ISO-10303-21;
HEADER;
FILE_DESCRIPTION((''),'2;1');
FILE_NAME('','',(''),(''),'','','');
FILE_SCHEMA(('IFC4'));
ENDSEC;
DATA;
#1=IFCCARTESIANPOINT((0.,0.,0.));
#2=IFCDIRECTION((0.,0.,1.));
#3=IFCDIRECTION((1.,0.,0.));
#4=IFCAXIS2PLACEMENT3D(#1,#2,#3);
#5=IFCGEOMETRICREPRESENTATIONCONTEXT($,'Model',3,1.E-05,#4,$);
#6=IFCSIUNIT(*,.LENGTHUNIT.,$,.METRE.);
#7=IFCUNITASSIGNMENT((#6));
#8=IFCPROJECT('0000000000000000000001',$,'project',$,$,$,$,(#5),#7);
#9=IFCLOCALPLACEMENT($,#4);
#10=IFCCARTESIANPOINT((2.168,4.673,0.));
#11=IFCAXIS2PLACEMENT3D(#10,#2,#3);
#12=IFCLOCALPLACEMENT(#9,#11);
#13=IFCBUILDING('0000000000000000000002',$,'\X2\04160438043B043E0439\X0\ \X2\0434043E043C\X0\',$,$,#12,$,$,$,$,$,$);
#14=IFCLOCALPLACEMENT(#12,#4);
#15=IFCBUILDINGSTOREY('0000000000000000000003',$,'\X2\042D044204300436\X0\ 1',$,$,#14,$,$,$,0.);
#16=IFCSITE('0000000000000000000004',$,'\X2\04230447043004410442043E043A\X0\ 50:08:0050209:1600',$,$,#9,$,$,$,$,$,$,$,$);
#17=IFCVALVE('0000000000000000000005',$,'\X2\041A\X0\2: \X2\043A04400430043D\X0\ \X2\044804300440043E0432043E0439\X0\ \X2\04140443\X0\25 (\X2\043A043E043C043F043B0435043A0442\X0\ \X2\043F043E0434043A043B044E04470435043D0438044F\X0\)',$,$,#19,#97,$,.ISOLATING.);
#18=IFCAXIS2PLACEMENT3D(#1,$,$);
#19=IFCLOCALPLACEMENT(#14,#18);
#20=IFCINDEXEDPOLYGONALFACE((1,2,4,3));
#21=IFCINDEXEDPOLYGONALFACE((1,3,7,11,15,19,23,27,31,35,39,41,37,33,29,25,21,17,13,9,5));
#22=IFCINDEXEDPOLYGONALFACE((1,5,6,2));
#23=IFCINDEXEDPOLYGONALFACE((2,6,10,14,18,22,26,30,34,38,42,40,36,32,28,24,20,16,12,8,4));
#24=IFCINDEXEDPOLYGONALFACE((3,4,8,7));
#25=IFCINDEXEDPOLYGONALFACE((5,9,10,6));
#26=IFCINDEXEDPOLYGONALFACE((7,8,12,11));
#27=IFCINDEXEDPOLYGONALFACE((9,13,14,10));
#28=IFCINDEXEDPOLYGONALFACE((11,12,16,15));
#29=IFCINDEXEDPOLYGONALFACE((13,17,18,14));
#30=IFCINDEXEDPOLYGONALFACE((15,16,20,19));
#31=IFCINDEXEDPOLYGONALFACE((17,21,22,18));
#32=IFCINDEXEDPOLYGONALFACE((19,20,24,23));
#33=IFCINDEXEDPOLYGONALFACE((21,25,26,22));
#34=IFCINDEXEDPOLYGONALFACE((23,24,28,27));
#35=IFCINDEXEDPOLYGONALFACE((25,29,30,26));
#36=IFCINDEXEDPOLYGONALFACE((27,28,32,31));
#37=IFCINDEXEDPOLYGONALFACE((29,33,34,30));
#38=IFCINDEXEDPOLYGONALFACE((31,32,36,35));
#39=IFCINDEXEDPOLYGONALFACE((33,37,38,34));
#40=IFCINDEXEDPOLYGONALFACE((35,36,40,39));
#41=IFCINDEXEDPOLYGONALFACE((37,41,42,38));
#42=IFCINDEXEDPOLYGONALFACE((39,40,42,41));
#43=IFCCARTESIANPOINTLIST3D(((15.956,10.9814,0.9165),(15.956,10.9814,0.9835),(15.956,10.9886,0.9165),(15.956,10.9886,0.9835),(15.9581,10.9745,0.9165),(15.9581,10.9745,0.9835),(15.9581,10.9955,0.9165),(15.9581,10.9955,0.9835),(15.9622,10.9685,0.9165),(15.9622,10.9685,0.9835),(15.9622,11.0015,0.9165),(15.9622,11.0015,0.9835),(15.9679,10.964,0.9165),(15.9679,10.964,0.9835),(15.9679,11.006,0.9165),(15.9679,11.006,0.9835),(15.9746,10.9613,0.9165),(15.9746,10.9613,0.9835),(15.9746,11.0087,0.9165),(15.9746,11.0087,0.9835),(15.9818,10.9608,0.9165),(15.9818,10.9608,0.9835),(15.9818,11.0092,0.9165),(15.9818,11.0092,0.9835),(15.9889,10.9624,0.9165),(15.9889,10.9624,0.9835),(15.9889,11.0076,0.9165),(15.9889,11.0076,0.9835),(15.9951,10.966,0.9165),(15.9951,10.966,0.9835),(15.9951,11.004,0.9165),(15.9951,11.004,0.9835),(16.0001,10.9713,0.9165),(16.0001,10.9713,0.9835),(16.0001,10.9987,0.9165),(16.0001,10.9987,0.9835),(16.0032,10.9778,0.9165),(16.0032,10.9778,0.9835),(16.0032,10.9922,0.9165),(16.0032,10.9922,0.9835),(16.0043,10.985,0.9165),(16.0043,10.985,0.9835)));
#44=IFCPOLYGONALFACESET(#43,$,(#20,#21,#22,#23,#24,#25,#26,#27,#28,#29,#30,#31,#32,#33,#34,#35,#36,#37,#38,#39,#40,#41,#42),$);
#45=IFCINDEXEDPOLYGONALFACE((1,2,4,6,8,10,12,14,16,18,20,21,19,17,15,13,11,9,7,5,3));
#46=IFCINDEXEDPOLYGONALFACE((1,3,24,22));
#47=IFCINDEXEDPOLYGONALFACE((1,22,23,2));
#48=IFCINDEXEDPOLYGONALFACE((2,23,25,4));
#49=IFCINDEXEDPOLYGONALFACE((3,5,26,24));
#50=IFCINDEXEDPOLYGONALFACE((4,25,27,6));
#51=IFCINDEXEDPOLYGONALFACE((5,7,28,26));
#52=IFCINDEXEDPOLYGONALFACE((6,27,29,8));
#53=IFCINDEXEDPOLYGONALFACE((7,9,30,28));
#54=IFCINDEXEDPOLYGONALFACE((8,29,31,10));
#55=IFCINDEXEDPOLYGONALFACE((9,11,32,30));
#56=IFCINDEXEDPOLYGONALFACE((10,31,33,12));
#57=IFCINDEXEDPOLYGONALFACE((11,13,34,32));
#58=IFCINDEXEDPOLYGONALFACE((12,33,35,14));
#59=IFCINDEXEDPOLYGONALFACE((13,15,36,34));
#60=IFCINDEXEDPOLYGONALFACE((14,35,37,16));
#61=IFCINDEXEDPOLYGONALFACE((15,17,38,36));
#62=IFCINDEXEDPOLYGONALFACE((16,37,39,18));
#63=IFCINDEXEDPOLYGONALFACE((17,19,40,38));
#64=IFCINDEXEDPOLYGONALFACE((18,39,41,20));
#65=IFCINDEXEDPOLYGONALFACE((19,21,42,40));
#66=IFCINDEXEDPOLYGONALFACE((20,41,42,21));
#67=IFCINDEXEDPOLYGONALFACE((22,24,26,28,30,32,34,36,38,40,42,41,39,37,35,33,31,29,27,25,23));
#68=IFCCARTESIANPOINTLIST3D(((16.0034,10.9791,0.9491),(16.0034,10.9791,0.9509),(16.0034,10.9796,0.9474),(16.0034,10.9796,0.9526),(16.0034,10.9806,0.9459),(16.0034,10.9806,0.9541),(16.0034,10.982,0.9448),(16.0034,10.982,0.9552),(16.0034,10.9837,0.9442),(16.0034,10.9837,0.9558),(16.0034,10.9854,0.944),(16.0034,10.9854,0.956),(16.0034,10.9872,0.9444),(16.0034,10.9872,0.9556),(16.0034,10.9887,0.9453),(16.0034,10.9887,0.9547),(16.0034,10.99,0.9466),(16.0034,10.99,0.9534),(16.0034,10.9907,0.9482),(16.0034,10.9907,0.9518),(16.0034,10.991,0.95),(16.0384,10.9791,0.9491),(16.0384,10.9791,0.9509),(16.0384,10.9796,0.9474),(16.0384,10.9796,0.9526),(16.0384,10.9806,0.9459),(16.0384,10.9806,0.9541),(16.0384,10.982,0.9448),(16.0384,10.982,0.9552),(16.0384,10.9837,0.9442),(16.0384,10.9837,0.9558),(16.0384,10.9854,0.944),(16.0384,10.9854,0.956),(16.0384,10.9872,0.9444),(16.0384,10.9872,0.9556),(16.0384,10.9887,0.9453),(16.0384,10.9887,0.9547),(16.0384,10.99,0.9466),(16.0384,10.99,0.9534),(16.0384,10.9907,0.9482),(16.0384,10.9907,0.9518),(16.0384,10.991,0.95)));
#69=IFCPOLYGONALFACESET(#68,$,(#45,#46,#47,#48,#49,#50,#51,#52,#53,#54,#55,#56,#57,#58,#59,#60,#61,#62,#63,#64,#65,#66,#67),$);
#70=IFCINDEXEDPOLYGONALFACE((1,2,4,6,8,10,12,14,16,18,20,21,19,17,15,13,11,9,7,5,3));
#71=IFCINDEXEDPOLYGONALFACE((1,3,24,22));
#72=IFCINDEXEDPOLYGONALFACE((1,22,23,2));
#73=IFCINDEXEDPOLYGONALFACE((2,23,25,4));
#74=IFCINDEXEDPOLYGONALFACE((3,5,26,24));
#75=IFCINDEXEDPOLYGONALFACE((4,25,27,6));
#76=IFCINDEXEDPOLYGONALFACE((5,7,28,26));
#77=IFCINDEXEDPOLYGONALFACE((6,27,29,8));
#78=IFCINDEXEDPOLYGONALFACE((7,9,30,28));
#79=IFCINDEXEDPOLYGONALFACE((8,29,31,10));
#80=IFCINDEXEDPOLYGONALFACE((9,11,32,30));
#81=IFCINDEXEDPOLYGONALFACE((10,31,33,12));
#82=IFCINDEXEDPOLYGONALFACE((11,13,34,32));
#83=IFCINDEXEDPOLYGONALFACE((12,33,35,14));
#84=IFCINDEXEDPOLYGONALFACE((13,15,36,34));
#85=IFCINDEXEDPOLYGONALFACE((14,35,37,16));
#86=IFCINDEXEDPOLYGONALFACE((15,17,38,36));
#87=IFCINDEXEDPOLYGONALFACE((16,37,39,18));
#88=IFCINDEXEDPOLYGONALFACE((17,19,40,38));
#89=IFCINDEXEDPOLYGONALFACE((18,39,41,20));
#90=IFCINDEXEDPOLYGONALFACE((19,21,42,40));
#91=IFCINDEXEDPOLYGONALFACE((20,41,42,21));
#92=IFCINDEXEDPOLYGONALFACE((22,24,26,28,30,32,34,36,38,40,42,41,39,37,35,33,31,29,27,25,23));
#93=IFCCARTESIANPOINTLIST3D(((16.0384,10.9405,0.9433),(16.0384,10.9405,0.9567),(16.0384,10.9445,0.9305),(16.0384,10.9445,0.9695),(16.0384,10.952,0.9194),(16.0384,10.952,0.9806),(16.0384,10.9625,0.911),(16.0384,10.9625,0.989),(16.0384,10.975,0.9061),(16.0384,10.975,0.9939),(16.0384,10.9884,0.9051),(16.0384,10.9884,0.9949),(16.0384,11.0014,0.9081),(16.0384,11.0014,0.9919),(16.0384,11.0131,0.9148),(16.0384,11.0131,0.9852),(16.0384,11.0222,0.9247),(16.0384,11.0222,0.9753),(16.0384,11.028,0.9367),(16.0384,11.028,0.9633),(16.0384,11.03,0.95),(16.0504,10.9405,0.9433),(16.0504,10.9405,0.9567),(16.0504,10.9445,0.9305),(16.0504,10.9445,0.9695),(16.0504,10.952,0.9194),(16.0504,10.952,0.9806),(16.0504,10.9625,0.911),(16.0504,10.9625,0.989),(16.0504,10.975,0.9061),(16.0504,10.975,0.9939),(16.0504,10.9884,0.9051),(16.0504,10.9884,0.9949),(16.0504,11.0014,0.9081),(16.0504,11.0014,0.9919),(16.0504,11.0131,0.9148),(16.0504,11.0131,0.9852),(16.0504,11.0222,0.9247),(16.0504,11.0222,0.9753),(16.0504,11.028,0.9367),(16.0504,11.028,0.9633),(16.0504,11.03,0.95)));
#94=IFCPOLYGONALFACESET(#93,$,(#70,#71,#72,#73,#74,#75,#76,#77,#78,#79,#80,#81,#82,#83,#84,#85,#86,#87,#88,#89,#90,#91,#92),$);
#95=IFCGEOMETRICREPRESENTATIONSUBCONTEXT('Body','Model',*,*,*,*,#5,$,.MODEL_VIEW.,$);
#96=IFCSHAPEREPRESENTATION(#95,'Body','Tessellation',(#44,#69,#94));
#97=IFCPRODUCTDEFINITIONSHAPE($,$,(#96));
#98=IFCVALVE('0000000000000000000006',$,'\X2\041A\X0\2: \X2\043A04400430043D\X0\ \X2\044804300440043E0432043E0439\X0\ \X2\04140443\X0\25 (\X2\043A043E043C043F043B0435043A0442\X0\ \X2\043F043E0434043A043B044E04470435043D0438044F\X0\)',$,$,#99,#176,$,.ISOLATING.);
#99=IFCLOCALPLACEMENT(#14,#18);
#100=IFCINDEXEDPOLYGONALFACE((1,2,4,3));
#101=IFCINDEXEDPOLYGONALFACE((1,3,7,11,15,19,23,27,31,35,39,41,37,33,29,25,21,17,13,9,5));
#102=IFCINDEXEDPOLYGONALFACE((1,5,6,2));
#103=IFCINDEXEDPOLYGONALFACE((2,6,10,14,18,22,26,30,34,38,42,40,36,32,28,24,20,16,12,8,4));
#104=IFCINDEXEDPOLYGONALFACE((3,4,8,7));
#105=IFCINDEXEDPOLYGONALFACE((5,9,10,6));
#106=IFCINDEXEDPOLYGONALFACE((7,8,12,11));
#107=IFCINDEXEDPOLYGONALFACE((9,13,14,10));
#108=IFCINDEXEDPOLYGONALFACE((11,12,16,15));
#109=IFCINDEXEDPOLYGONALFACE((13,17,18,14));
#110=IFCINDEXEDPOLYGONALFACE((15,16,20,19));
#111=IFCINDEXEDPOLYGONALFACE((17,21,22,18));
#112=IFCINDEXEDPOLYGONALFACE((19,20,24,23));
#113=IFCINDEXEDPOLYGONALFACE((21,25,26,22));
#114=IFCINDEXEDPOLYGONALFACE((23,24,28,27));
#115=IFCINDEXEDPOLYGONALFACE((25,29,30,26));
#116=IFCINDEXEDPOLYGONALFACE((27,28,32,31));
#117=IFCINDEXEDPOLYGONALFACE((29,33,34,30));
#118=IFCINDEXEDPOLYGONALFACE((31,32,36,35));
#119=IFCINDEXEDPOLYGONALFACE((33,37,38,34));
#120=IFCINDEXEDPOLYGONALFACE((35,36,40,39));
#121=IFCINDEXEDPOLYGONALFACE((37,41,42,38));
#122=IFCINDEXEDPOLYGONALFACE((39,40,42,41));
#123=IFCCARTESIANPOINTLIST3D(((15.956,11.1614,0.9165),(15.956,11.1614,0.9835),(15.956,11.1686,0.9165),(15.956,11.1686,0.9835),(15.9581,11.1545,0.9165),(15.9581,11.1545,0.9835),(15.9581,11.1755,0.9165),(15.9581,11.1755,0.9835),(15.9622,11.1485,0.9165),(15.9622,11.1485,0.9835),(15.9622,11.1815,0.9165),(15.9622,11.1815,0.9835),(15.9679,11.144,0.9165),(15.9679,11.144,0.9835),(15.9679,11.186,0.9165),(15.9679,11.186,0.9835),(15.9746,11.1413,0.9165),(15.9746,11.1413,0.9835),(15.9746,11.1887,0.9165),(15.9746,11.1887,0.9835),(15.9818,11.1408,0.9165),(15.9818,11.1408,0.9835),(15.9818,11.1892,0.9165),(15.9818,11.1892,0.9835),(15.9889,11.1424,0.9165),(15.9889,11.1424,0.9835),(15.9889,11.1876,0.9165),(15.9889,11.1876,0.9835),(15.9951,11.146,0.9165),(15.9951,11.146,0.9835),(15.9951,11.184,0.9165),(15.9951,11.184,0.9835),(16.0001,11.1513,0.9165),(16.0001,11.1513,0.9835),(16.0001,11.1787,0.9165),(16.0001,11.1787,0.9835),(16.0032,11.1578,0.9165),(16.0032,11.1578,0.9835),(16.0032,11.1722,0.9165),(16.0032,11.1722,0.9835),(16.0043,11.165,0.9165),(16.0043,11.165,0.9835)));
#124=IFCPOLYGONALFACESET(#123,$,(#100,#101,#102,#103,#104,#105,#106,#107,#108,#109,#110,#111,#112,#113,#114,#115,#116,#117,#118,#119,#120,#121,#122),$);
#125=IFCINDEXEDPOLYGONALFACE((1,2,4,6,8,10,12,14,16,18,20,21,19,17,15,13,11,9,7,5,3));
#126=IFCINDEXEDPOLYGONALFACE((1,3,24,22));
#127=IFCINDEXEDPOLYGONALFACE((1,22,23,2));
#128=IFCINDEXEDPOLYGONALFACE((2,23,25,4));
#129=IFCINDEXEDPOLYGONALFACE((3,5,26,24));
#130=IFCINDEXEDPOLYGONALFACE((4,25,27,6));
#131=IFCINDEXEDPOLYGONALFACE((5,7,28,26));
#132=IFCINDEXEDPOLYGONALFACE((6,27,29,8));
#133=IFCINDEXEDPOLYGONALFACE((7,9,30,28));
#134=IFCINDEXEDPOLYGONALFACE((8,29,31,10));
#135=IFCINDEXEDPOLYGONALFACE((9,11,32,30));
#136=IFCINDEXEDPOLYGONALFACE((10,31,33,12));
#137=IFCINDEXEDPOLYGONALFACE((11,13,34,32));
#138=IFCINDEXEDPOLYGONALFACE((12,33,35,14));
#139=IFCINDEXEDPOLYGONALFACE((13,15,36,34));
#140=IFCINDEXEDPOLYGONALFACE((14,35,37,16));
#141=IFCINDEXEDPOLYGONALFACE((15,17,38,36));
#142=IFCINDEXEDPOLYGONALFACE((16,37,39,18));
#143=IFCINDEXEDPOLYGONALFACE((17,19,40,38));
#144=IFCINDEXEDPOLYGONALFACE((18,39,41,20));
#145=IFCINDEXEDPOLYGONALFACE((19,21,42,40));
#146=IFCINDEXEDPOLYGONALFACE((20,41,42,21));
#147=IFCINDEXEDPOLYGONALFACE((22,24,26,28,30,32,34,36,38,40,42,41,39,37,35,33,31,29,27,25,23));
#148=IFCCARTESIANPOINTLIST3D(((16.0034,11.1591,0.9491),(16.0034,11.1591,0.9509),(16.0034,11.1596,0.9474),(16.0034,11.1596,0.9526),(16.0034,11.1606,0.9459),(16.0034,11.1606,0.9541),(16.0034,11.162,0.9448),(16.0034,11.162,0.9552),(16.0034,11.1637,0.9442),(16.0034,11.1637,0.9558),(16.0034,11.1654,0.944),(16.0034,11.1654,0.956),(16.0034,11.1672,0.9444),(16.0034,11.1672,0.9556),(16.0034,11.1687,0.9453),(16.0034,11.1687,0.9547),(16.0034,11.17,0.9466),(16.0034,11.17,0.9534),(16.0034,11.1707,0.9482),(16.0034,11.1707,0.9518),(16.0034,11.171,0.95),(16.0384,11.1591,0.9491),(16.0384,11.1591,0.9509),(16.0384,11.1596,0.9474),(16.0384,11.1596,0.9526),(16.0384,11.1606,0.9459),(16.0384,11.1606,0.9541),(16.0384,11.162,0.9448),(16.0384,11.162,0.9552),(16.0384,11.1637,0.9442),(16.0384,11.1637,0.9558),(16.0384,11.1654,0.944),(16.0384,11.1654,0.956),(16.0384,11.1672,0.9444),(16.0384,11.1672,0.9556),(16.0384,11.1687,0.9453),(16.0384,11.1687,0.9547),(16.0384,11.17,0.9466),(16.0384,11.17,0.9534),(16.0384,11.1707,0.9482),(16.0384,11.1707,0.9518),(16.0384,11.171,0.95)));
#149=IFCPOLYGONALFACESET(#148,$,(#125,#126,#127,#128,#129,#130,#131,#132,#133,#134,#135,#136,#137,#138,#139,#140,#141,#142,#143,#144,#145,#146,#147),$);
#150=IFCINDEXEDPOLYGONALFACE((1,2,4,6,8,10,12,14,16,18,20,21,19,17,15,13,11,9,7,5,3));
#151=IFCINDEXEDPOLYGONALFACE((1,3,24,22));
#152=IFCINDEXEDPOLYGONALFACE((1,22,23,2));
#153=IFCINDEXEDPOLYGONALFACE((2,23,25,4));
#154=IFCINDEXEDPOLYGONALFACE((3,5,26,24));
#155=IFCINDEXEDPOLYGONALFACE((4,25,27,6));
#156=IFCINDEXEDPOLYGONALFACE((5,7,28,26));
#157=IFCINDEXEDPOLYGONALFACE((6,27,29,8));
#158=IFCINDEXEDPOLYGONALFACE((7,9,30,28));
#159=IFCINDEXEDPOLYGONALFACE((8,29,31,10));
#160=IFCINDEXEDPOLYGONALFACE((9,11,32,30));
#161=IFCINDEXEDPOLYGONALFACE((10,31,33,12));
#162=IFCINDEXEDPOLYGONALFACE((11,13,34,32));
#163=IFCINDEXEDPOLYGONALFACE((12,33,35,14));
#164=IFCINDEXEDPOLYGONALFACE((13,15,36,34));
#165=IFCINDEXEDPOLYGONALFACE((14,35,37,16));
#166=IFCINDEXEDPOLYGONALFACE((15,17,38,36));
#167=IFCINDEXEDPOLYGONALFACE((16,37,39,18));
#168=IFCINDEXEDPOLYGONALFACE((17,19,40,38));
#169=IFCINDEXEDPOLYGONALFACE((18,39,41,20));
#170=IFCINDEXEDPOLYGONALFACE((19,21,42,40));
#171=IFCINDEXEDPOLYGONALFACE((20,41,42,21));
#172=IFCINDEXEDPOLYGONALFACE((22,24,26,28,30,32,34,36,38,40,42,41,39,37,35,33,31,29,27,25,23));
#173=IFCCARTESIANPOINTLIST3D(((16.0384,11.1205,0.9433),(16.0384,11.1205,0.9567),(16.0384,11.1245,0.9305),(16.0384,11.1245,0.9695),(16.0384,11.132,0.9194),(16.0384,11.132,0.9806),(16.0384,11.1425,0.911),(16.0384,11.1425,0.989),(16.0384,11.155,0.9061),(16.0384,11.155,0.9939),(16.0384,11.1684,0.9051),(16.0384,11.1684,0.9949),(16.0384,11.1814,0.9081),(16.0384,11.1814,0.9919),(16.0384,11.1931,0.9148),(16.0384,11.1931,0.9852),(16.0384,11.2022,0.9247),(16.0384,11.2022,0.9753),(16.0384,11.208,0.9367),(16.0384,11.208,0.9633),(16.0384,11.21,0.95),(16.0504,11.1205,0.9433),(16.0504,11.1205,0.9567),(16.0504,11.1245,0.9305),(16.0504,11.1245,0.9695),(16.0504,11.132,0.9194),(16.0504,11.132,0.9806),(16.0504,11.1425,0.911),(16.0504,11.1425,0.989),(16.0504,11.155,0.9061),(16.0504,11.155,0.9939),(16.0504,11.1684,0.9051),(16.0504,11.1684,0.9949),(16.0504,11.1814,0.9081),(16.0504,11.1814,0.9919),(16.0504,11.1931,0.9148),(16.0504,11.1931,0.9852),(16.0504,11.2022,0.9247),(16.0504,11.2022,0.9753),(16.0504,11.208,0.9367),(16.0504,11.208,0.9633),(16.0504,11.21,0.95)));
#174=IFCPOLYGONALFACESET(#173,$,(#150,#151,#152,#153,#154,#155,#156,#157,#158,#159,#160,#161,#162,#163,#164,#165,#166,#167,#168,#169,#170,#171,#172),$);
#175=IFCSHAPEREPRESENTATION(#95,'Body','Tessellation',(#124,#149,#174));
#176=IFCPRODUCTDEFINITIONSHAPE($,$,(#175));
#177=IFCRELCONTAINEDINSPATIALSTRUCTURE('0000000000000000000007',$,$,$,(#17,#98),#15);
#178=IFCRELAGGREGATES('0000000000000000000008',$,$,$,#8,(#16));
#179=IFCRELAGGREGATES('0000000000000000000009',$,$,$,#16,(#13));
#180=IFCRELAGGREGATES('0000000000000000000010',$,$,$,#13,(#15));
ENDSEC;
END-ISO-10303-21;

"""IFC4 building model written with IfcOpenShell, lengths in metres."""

from ifc_helpers import new_model, si_unit, frame, origin_with_axes, origin_2d, place, context, subcontext, project, spatial, circle, extrude, element, save


model = new_model("IFC4")

# Units and contexts
model_context = context("Model", 3, precision=1e-05, world=origin_with_axes())
body_context = subcontext(model_context, "Body", "Model", "MODEL_VIEW")
ifc_project = project(units=[si_unit("LENGTHUNIT", "METRE")], contexts=[model_context])

# Site, building, storey
site_placement = place(None, origin_with_axes())
site = spatial("IfcSite", under=ifc_project, at=site_placement, Name="Участок 50:08:0050209:1600")
building_placement = place(site_placement, frame((2.168, 4.673, 0.0), z_axis=(0.0, 0.0, 1.0), x_axis=(1.0, 0.0, 0.0)))
building = spatial("IfcBuilding", under=site, at=building_placement, Name="Жилой дом")
storey_placement = place(building_placement, origin_with_axes())
storey = spatial("IfcBuildingStorey", under=building, at=storey_placement, Name="Этаж 1", Elevation=0.0)

# Valves
valve_1_placement = place(storey_placement, origin_with_axes())
element("IfcValve", 1, at=valve_1_placement, inside=storey, Name="К2: кран шаровой Ду25 (комплект подключения)", PredefinedType="ISOLATING", context=body_context, shape_type="SweptSolid", body=[
    extrude(circle(Radius=0.0243, at=origin_2d()), frame((15.98, 10.985, 0.9165), z_axis=(0.0, 0.0, 1.0), x_axis=(1.0, 0.0, 0.0)), (0.0, 0.0, 1.0), 0.067),
    extrude(circle(Radius=0.006, at=origin_2d()), frame((16.0035, 10.985, 0.95), z_axis=(1.0, 0.0, 0.0), x_axis=(0.0, 1.0, 0.0)), (0.0, 0.0, 1.0), 0.035),
    extrude(circle(Radius=0.045, at=origin_2d()), frame((16.0385, 10.985, 0.95), z_axis=(1.0, 0.0, 0.0), x_axis=(0.0, 1.0, 0.0)), (0.0, 0.0, 1.0), 0.012),
])
valve_2_placement = place(storey_placement, origin_with_axes())
element("IfcValve", 2, at=valve_2_placement, inside=storey, Name="К2: кран шаровой Ду25 (комплект подключения)", PredefinedType="ISOLATING", context=body_context, shape_type="SweptSolid", body=[
    extrude(circle(Radius=0.0243, at=origin_2d()), frame((15.98, 11.165, 0.9165), z_axis=(0.0, 0.0, 1.0), x_axis=(1.0, 0.0, 0.0)), (0.0, 0.0, 1.0), 0.067),
    extrude(circle(Radius=0.006, at=origin_2d()), frame((16.0035, 11.165, 0.95), z_axis=(1.0, 0.0, 0.0), x_axis=(0.0, 1.0, 0.0)), (0.0, 0.0, 1.0), 0.035),
    extrude(circle(Radius=0.045, at=origin_2d()), frame((16.0385, 11.165, 0.95), z_axis=(1.0, 0.0, 0.0), x_axis=(0.0, 1.0, 0.0)), (0.0, 0.0, 1.0), 0.012),
])

save(model, "model.ifc")
